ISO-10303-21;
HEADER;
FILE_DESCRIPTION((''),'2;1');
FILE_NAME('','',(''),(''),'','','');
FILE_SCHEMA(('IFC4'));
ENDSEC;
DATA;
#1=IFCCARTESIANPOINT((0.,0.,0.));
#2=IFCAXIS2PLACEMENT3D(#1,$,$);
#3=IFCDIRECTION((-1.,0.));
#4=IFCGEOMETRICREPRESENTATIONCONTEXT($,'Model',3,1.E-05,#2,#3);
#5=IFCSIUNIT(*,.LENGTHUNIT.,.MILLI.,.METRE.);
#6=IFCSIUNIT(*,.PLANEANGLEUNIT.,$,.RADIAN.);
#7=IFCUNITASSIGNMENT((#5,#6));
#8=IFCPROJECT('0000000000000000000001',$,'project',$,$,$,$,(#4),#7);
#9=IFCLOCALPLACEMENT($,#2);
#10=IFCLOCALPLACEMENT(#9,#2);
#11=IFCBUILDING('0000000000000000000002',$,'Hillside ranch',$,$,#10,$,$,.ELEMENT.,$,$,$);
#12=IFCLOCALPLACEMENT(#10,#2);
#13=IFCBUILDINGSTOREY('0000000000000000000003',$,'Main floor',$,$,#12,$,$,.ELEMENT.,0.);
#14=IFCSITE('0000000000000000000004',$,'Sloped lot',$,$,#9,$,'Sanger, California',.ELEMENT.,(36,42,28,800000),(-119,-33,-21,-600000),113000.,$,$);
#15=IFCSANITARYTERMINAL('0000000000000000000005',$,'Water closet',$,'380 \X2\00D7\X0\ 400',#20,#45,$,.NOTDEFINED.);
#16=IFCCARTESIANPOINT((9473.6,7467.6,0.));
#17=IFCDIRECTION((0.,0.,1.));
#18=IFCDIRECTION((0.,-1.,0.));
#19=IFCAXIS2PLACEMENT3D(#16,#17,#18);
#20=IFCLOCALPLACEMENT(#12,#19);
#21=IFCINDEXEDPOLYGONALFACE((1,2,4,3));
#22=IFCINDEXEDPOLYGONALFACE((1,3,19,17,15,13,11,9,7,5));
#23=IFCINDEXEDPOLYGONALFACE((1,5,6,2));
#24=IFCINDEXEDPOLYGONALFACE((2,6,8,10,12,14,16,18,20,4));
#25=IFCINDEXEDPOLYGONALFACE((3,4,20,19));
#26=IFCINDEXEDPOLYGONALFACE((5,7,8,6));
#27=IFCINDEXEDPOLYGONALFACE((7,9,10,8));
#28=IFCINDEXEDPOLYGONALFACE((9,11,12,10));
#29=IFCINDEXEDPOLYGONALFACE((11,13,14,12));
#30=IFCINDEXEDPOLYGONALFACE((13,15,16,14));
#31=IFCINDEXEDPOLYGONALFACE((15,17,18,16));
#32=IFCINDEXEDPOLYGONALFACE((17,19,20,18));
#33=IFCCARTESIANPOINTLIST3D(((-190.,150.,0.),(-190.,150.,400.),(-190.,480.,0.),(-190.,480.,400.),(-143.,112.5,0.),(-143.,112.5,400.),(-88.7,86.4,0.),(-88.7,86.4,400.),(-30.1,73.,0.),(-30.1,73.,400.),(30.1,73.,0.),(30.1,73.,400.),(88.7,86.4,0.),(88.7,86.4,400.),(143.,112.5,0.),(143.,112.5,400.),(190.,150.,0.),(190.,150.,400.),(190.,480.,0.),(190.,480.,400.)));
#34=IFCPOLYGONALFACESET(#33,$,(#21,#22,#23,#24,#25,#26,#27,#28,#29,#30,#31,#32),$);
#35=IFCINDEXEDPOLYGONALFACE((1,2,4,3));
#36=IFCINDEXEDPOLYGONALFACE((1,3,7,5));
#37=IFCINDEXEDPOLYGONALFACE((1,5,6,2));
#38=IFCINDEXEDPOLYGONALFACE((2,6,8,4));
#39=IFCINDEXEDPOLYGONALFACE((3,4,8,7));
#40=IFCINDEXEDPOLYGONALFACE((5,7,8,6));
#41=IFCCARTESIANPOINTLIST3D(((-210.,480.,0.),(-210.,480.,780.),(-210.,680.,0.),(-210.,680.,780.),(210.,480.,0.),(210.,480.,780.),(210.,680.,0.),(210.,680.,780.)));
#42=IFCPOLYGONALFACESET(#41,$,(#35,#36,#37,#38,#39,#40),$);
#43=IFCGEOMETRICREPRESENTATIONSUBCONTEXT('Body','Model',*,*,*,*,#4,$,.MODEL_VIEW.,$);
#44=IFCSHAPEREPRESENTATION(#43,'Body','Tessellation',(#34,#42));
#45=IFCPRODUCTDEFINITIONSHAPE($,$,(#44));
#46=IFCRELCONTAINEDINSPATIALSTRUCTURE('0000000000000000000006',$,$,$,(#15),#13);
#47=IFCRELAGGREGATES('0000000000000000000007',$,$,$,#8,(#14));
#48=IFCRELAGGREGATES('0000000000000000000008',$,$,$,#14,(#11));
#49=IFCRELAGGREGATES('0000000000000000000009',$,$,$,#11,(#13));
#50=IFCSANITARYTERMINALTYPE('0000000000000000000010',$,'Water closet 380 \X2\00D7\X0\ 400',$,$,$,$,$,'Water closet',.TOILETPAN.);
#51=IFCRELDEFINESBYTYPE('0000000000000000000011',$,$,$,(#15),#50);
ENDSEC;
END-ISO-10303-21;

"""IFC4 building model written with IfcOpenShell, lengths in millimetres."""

from ifc_helpers import new_model, si_unit, direction, frame, origin, origin_with_axes, place, context, subcontext, project, spatial, polyline, line, arc, indexed_curve, outline, extrude, source, transform, mapped, type_object, type_shapes, element, save


model = new_model("IFC4")

# Units and contexts
model_context = context("Model", 3, precision=1e-05, world=origin(), true_north=direction((-1.0, 0.0)))
body_context = subcontext(model_context, "Body", "Model", "MODEL_VIEW")
ifc_project = project(units=[si_unit("LENGTHUNIT", "METRE", prefix="MILLI"), si_unit("PLANEANGLEUNIT", "RADIAN")], contexts=[model_context])

# Site, building, storey
site_placement = place(None, origin())
site = spatial("IfcSite", under=ifc_project, at=site_placement, Name="Sloped lot", LongName="Sanger, California", CompositionType="ELEMENT", RefLatitude=(36, 42, 28, 800000), RefLongitude=(-119, -33, -21, -600000), RefElevation=113000.0)
building_placement = place(site_placement, origin())
building = spatial("IfcBuilding", under=site, at=building_placement, Name="Hillside ranch", CompositionType="ELEMENT")
storey_placement = place(building_placement, origin())
storey = spatial("IfcBuildingStorey", under=building, at=storey_placement, Name="Main floor", CompositionType="ELEMENT", Elevation=0.0)

# Sanitary terminal
sanitary_terminal_type_1 = type_object("IfcSanitaryTerminalType", Name="Water closet 380 × 400", ElementType="Water closet", PredefinedType="TOILETPAN")
shared_shape_1 = source(origin(), body_context, "Body", "SweptSolid", [
    extrude(outline(indexed_curve([(-190.0, 480.0), (-190.0, 150.0), (0.0, 71.3), (190.0, 150.0), (190.0, 480.0)], segments=[line(1, 2), arc(2, 3, 4), line(4, 5), line(5, 1)], self_intersect=False)), origin_with_axes(), (0.0, 0.0, 1.0), 400.0),
    extrude(outline(polyline([(-210.0, 480.0), (210.0, 480.0), (210.0, 680.0), (-210.0, 680.0), (-210.0, 480.0)])), origin(), (0.0, 0.0, 1.0), 780.0),
])
type_shapes(sanitary_terminal_type_1, [shared_shape_1])
sanitary_terminal_1_placement = place(storey_placement, frame((9473.6, 7467.6, 0.0), z_axis=(0.0, 0.0, 1.0), x_axis=(0.0, -1.0, 0.0)))
element("IfcSanitaryTerminal", 1, at=sanitary_terminal_1_placement, inside=storey, type_object=sanitary_terminal_type_1, Name="Water closet", ObjectType="380 × 400", PredefinedType="NOTDEFINED", context=body_context, shape_type="MappedRepresentation", body=[
    mapped(shared_shape_1, transform((0.0, 0.0, 0.0))),
])

save(model, "model.ifc")
